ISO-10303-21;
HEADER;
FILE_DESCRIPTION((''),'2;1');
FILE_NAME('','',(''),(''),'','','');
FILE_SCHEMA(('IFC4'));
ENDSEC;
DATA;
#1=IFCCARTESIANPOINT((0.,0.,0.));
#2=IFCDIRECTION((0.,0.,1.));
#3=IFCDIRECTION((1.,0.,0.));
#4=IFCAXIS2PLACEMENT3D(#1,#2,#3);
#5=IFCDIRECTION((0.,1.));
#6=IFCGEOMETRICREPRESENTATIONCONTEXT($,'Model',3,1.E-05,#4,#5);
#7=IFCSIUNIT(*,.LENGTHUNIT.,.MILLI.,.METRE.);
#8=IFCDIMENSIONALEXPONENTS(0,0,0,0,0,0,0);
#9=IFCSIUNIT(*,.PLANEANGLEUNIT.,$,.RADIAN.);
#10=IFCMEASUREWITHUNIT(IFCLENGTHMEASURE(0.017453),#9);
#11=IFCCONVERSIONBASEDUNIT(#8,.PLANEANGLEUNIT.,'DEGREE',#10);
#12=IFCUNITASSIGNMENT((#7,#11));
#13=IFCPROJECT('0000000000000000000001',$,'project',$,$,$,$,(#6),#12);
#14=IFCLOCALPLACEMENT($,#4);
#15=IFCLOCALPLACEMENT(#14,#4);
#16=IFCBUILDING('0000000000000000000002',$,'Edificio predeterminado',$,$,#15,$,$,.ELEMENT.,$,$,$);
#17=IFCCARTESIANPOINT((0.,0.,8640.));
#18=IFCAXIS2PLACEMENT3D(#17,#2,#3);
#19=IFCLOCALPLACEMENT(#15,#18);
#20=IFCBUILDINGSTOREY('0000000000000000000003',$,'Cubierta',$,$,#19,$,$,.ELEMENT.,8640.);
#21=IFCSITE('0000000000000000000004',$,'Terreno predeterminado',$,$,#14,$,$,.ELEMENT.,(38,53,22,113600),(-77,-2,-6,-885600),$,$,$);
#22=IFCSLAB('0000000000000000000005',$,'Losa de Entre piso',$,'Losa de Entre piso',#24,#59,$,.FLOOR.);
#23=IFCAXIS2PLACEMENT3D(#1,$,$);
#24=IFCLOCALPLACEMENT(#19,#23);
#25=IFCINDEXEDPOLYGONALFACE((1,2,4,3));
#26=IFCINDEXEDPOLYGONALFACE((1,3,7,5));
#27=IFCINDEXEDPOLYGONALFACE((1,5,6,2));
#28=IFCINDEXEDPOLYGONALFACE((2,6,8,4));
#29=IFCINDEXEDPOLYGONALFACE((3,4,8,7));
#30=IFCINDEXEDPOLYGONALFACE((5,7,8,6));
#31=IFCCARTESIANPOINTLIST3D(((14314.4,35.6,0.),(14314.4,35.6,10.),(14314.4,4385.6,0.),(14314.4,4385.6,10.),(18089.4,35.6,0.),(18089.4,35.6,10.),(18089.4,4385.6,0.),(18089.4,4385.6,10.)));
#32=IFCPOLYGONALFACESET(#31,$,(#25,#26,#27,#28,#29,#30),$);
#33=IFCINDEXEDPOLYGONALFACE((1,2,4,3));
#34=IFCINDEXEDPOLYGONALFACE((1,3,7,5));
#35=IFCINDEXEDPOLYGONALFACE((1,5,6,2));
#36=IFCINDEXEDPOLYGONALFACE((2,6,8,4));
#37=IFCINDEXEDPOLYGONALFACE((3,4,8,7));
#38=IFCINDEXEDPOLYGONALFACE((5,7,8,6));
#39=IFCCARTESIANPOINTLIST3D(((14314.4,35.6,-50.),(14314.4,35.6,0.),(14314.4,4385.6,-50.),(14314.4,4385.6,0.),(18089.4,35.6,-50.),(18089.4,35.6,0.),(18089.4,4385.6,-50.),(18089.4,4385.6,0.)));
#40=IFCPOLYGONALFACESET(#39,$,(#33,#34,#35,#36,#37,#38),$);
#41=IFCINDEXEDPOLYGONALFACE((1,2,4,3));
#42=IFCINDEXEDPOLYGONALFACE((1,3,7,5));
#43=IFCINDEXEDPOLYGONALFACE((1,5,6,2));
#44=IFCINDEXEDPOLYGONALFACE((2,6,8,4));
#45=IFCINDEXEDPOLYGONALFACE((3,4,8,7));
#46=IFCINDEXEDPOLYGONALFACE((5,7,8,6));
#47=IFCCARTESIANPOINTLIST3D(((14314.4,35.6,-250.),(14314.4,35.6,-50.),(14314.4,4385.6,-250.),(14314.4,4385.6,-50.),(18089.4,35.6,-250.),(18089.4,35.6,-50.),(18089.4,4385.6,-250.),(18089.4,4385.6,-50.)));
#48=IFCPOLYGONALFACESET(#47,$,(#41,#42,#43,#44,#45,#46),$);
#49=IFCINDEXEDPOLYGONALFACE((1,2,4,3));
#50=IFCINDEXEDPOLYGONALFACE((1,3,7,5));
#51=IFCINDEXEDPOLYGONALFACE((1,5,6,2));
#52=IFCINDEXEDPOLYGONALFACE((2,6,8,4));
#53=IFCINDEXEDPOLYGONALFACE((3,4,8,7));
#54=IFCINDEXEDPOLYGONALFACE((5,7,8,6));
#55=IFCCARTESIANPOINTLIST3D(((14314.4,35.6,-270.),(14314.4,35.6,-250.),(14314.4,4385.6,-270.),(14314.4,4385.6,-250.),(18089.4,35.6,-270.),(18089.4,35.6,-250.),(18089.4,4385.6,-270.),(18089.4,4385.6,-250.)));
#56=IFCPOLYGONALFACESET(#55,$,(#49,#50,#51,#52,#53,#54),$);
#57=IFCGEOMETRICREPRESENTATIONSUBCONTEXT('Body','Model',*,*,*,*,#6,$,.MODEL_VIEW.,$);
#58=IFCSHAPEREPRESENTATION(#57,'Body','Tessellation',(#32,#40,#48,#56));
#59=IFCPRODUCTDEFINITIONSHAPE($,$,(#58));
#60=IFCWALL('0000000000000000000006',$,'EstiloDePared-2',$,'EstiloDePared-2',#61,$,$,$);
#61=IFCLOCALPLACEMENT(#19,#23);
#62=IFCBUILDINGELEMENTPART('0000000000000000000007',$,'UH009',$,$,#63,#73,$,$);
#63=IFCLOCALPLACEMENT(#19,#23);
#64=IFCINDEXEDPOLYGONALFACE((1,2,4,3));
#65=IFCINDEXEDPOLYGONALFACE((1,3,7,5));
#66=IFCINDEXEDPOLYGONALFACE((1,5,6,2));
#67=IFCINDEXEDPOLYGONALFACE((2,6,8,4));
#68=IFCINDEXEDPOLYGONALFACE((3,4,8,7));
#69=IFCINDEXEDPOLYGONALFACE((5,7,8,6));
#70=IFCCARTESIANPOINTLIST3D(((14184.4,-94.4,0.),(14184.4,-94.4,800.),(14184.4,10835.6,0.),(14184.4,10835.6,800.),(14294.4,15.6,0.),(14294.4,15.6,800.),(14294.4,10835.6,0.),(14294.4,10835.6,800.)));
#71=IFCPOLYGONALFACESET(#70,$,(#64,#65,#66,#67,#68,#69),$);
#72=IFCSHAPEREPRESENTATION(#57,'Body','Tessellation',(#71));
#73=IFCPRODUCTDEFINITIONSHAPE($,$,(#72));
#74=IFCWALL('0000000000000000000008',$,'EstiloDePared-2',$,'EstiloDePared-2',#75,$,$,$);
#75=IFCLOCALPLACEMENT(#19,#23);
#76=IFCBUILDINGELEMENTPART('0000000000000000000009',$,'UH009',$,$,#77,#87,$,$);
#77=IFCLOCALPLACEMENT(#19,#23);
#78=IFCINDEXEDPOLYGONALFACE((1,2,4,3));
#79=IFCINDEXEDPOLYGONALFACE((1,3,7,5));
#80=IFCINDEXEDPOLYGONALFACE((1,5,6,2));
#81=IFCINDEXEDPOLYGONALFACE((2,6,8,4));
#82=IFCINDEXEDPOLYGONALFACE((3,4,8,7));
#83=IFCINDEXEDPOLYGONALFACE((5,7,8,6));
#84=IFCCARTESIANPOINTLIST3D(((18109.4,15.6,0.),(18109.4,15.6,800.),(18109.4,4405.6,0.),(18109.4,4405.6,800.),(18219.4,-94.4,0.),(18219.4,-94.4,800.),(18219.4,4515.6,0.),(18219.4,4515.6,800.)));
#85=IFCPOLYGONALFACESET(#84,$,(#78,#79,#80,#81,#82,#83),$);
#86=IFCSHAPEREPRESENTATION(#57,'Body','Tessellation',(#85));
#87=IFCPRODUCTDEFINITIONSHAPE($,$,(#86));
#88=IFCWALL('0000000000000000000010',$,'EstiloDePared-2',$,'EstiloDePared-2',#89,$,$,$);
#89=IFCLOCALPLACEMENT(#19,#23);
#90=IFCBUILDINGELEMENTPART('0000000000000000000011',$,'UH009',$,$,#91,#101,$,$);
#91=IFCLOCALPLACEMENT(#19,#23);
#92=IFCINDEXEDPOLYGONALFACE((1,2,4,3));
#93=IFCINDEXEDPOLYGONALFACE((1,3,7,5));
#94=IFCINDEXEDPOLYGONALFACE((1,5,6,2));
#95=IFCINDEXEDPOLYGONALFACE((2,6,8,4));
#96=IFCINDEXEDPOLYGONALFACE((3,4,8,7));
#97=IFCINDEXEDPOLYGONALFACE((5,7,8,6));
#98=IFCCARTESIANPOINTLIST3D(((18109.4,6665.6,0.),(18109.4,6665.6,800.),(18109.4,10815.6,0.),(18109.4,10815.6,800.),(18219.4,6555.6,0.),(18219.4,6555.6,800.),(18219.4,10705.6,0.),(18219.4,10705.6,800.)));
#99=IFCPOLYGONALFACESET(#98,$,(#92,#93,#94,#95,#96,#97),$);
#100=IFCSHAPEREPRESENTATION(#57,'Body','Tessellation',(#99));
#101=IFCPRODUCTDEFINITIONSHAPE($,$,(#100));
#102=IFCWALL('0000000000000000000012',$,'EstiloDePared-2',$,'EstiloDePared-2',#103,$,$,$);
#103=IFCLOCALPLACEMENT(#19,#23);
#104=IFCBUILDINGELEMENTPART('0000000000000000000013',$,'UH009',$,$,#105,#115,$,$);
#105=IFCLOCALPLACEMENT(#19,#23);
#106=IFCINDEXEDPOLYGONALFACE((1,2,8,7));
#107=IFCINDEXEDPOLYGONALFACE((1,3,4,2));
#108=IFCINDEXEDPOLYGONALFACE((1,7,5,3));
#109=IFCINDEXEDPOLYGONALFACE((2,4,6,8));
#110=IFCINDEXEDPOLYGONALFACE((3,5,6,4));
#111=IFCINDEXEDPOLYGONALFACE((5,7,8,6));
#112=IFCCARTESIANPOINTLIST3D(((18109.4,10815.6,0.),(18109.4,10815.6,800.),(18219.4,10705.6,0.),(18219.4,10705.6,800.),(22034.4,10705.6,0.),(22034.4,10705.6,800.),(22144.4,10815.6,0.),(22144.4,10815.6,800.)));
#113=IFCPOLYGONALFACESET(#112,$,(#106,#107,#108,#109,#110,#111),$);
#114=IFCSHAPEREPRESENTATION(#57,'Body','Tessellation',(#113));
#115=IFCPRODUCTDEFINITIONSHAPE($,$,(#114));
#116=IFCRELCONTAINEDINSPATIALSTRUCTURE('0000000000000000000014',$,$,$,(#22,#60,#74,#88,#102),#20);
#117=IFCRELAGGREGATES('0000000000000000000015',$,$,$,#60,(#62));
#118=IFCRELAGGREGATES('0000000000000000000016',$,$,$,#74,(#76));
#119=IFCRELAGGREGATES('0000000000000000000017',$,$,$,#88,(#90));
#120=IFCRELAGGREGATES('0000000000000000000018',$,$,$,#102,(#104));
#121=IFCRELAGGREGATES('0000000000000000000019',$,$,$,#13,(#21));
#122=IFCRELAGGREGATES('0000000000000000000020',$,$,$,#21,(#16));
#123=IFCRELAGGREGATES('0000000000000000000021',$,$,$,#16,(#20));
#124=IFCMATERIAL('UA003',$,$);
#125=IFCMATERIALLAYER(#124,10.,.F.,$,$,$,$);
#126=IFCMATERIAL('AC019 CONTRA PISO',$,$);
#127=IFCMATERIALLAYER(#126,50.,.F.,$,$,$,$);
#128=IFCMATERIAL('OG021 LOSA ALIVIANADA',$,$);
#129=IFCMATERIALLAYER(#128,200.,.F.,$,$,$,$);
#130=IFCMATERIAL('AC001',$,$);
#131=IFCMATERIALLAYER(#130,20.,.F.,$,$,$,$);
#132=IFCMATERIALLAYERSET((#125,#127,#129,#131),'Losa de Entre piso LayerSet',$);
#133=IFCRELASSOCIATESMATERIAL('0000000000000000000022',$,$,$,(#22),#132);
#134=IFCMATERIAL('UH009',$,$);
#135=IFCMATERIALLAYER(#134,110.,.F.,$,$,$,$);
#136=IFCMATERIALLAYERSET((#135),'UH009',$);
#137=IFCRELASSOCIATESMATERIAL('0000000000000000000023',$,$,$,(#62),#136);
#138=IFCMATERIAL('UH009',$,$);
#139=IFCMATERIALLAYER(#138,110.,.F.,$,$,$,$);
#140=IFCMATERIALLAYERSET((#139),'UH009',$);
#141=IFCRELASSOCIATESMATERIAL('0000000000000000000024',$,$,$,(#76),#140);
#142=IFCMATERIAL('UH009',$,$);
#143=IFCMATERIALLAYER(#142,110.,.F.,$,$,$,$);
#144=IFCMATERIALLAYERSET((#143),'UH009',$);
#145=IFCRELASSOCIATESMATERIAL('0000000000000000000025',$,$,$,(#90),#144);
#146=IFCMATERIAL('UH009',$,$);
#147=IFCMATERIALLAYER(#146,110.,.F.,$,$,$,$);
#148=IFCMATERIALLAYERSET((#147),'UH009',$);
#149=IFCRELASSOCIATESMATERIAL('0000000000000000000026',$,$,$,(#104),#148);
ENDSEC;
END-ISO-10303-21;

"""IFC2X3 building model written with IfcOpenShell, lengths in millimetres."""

from ifc_helpers import new_model, entity, si_unit, converted_unit, direction, frame, origin_with_axes, place, context, subcontext, project, spatial, polyline, outline, extrude, material, layer, layer_set, layer_usage, element, aggregate, save


model = new_model("IFC2X3")

# Units and contexts
model_context = context("Model", 3, precision=1e-05, world=origin_with_axes(), true_north=direction((0.0, 1.0)))
body_context = subcontext(model_context, "Body", "Model", "MODEL_VIEW")
ifc_project = project(units=[si_unit("LENGTHUNIT", "METRE", prefix="MILLI"), converted_unit("PLANEANGLEUNIT", "DEGREE", entity("IfcLengthMeasure", 0.017453), si_unit("PLANEANGLEUNIT", "RADIAN"), dimensions=[0, 0, 0, 0, 0, 0, 0])], contexts=[model_context])

# Site, building, storey
site_placement = place(None, origin_with_axes())
site = spatial("IfcSite", under=ifc_project, at=site_placement, Name="Terreno predeterminado", CompositionType="ELEMENT", RefLatitude=(38, 53, 22, 113600), RefLongitude=(-77, -2, -6, -885600))
building_placement = place(site_placement, origin_with_axes())
building = spatial("IfcBuilding", under=site, at=building_placement, Name="Edificio predeterminado", CompositionType="ELEMENT")
storey_placement = place(building_placement, frame((0.0, 0.0, 8640.0), z_axis=(0.0, 0.0, 1.0), x_axis=(1.0, 0.0, 0.0)))
storey = spatial("IfcBuildingStorey", under=building, at=storey_placement, Name="Cubierta", CompositionType="ELEMENT", Elevation=8640.0)

# Slab
ifc_material_1 = material(Name="UA003")
ifc_layer_1 = layer(ifc_material_1, 10.0, ventilated=False)
ifc_material_2 = material(Name="AC019 CONTRA PISO")
ifc_layer_2 = layer(ifc_material_2, 50.0, ventilated=False)
ifc_material_3 = material(Name="OG021 LOSA ALIVIANADA")
ifc_layer_3 = layer(ifc_material_3, 200.0, ventilated=False)
ifc_material_4 = material(Name="AC001")
ifc_layer_4 = layer(ifc_material_4, 20.0, ventilated=False)
ifc_layer_set_1 = layer_set([ifc_layer_1, ifc_layer_2, ifc_layer_3, ifc_layer_4], Name="Losa de Entre piso LayerSet")
ifc_layer_usage_1 = layer_usage(ifc_layer_set_1, "AXIS3", "NEGATIVE", 0.0)
slab_1_placement = place(storey_placement, frame((0.0, 0.0, -8640.0), z_axis=(0.0, 0.0, 1.0), x_axis=(1.0, 0.0, 0.0)))
element("IfcSlab", 1, at=slab_1_placement, inside=storey, material=ifc_layer_usage_1, Name="Losa de Entre piso", ObjectType="Losa de Entre piso", PredefinedType="FLOOR", context=body_context, shape_type="SweptSolid", body=[
    extrude(outline(polyline([(0.0, 4350.0), (3775.0, 4350.0), (3775.0, 0.0), (0.0, 0.0), (0.0, 4350.0)])), frame((18089.4, 35.6, 8640.0), z_axis=(0.0, 0.0, -1.0), x_axis=(-1.0, 0.0, 0.0)), (0.0, 0.0, -1.0), 10.0),
    extrude(outline(polyline([(0.0, 4350.0), (3775.0, 4350.0), (3775.0, 0.0), (0.0, 0.0), (0.0, 4350.0)])), frame((18089.4, 35.6, 8590.0), z_axis=(0.0, 0.0, -1.0), x_axis=(-1.0, 0.0, 0.0)), (0.0, 0.0, -1.0), 50.0),
    extrude(outline(polyline([(0.0, 4350.0), (3775.0, 4350.0), (3775.0, 0.0), (0.0, 0.0), (0.0, 4350.0)])), frame((18089.4, 35.6, 8390.0), z_axis=(0.0, 0.0, -1.0), x_axis=(-1.0, 0.0, 0.0)), (0.0, 0.0, -1.0), 200.0),
    extrude(outline(polyline([(0.0, 4350.0), (3775.0, 4350.0), (3775.0, 0.0), (0.0, 0.0), (0.0, 4350.0)])), frame((18089.4, 35.6, 8370.0), z_axis=(0.0, 0.0, -1.0), x_axis=(-1.0, 0.0, 0.0)), (0.0, 0.0, -1.0), 20.0),
])

# Walls, building element parts
wall_1_placement = place(storey_placement, frame((14239.4, -39.4, 0.0), z_axis=(0.0, 0.0, 1.0), x_axis=(0.0, 1.0, 0.0)))
wall_1 = element("IfcWall", 2, at=wall_1_placement, inside=storey, Name="EstiloDePared-2", ObjectType="EstiloDePared-2")
ifc_material_5 = material(Name="UH009")
ifc_layer_5 = layer(ifc_material_5, 110.0, ventilated=False)
ifc_layer_set_2 = layer_set([ifc_layer_5], Name="UH009")
ifc_layer_usage_2 = layer_usage(ifc_layer_set_2, "AXIS2", "NEGATIVE", -55.0)
building_element_part_1_placement = place(wall_1_placement, origin_with_axes())
building_element_part_1 = element("IfcBuildingElementPart", 3, at=building_element_part_1_placement, material=ifc_layer_usage_2, Name="UH009", context=body_context, shape_type="SweptSolid", body=[
    extrude(outline(polyline([(10875.0, 55.0), (10875.0, -55.0), (55.0, -55.0), (-55.0, 55.0), (10875.0, 55.0)])), origin_with_axes(), (0.0, 0.0, 1.0), 800.0),
])
aggregate(wall_1, [building_element_part_1])
wall_2_placement = place(storey_placement, frame((18164.4, -39.4, 0.0), z_axis=(0.0, 0.0, 1.0), x_axis=(0.0, 1.0, 0.0)))
wall_2 = element("IfcWall", 4, at=wall_2_placement, inside=storey, Name="EstiloDePared-2", ObjectType="EstiloDePared-2")
ifc_material_6 = material(Name="UH009")
ifc_layer_6 = layer(ifc_material_6, 110.0, ventilated=False)
ifc_layer_set_3 = layer_set([ifc_layer_6], Name="UH009")
ifc_layer_usage_3 = layer_usage(ifc_layer_set_3, "AXIS2", "NEGATIVE", -55.0)
building_element_part_2_placement = place(wall_2_placement, origin_with_axes())
building_element_part_2 = element("IfcBuildingElementPart", 5, at=building_element_part_2_placement, material=ifc_layer_usage_3, Name="UH009", context=body_context, shape_type="SweptSolid", body=[
    extrude(outline(polyline([(4445.0, 55.0), (4555.0, -55.0), (-55.0, -55.0), (55.0, 55.0), (4445.0, 55.0)])), origin_with_axes(), (0.0, 0.0, 1.0), 800.0),
])
aggregate(wall_2, [building_element_part_2])
wall_3_placement = place(storey_placement, frame((18164.4, 6610.6, 0.0), z_axis=(0.0, 0.0, 1.0), x_axis=(0.0, 1.0, 0.0)))
wall_3 = element("IfcWall", 6, at=wall_3_placement, inside=storey, Name="EstiloDePared-2", ObjectType="EstiloDePared-2")
ifc_material_7 = material(Name="UH009")
ifc_layer_7 = layer(ifc_material_7, 110.0, ventilated=False)
ifc_layer_set_4 = layer_set([ifc_layer_7], Name="UH009")
ifc_layer_usage_4 = layer_usage(ifc_layer_set_4, "AXIS2", "NEGATIVE", -55.0)
building_element_part_3_placement = place(wall_3_placement, origin_with_axes())
building_element_part_3 = element("IfcBuildingElementPart", 7, at=building_element_part_3_placement, material=ifc_layer_usage_4, Name="UH009", context=body_context, shape_type="SweptSolid", body=[
    extrude(outline(polyline([(4205.0, 55.0), (4095.0, -55.0), (-55.0, -55.0), (55.0, 55.0), (4205.0, 55.0)])), origin_with_axes(), (0.0, 0.0, 1.0), 800.0),
])
aggregate(wall_3, [building_element_part_3])
wall_4_placement = place(storey_placement, frame((18164.4, 10760.6, 0.0), z_axis=(0.0, 0.0, 1.0), x_axis=(1.0, 0.0, 0.0)))
wall_4 = element("IfcWall", 8, at=wall_4_placement, inside=storey, Name="EstiloDePared-2", ObjectType="EstiloDePared-2")
ifc_material_8 = material(Name="UH009")
ifc_layer_8 = layer(ifc_material_8, 110.0, ventilated=False)
ifc_layer_set_5 = layer_set([ifc_layer_8], Name="UH009")
ifc_layer_usage_5 = layer_usage(ifc_layer_set_5, "AXIS2", "NEGATIVE", -55.0)
building_element_part_4_placement = place(wall_4_placement, origin_with_axes())
building_element_part_4 = element("IfcBuildingElementPart", 9, at=building_element_part_4_placement, material=ifc_layer_usage_5, Name="UH009", context=body_context, shape_type="SweptSolid", body=[
    extrude(outline(polyline([(3980.0, 55.0), (3870.0, -55.0), (55.0, -55.0), (-55.0, 55.0), (3980.0, 55.0)])), origin_with_axes(), (0.0, 0.0, 1.0), 800.0),
])
aggregate(wall_4, [building_element_part_4])

save(model, "model.ifc")
